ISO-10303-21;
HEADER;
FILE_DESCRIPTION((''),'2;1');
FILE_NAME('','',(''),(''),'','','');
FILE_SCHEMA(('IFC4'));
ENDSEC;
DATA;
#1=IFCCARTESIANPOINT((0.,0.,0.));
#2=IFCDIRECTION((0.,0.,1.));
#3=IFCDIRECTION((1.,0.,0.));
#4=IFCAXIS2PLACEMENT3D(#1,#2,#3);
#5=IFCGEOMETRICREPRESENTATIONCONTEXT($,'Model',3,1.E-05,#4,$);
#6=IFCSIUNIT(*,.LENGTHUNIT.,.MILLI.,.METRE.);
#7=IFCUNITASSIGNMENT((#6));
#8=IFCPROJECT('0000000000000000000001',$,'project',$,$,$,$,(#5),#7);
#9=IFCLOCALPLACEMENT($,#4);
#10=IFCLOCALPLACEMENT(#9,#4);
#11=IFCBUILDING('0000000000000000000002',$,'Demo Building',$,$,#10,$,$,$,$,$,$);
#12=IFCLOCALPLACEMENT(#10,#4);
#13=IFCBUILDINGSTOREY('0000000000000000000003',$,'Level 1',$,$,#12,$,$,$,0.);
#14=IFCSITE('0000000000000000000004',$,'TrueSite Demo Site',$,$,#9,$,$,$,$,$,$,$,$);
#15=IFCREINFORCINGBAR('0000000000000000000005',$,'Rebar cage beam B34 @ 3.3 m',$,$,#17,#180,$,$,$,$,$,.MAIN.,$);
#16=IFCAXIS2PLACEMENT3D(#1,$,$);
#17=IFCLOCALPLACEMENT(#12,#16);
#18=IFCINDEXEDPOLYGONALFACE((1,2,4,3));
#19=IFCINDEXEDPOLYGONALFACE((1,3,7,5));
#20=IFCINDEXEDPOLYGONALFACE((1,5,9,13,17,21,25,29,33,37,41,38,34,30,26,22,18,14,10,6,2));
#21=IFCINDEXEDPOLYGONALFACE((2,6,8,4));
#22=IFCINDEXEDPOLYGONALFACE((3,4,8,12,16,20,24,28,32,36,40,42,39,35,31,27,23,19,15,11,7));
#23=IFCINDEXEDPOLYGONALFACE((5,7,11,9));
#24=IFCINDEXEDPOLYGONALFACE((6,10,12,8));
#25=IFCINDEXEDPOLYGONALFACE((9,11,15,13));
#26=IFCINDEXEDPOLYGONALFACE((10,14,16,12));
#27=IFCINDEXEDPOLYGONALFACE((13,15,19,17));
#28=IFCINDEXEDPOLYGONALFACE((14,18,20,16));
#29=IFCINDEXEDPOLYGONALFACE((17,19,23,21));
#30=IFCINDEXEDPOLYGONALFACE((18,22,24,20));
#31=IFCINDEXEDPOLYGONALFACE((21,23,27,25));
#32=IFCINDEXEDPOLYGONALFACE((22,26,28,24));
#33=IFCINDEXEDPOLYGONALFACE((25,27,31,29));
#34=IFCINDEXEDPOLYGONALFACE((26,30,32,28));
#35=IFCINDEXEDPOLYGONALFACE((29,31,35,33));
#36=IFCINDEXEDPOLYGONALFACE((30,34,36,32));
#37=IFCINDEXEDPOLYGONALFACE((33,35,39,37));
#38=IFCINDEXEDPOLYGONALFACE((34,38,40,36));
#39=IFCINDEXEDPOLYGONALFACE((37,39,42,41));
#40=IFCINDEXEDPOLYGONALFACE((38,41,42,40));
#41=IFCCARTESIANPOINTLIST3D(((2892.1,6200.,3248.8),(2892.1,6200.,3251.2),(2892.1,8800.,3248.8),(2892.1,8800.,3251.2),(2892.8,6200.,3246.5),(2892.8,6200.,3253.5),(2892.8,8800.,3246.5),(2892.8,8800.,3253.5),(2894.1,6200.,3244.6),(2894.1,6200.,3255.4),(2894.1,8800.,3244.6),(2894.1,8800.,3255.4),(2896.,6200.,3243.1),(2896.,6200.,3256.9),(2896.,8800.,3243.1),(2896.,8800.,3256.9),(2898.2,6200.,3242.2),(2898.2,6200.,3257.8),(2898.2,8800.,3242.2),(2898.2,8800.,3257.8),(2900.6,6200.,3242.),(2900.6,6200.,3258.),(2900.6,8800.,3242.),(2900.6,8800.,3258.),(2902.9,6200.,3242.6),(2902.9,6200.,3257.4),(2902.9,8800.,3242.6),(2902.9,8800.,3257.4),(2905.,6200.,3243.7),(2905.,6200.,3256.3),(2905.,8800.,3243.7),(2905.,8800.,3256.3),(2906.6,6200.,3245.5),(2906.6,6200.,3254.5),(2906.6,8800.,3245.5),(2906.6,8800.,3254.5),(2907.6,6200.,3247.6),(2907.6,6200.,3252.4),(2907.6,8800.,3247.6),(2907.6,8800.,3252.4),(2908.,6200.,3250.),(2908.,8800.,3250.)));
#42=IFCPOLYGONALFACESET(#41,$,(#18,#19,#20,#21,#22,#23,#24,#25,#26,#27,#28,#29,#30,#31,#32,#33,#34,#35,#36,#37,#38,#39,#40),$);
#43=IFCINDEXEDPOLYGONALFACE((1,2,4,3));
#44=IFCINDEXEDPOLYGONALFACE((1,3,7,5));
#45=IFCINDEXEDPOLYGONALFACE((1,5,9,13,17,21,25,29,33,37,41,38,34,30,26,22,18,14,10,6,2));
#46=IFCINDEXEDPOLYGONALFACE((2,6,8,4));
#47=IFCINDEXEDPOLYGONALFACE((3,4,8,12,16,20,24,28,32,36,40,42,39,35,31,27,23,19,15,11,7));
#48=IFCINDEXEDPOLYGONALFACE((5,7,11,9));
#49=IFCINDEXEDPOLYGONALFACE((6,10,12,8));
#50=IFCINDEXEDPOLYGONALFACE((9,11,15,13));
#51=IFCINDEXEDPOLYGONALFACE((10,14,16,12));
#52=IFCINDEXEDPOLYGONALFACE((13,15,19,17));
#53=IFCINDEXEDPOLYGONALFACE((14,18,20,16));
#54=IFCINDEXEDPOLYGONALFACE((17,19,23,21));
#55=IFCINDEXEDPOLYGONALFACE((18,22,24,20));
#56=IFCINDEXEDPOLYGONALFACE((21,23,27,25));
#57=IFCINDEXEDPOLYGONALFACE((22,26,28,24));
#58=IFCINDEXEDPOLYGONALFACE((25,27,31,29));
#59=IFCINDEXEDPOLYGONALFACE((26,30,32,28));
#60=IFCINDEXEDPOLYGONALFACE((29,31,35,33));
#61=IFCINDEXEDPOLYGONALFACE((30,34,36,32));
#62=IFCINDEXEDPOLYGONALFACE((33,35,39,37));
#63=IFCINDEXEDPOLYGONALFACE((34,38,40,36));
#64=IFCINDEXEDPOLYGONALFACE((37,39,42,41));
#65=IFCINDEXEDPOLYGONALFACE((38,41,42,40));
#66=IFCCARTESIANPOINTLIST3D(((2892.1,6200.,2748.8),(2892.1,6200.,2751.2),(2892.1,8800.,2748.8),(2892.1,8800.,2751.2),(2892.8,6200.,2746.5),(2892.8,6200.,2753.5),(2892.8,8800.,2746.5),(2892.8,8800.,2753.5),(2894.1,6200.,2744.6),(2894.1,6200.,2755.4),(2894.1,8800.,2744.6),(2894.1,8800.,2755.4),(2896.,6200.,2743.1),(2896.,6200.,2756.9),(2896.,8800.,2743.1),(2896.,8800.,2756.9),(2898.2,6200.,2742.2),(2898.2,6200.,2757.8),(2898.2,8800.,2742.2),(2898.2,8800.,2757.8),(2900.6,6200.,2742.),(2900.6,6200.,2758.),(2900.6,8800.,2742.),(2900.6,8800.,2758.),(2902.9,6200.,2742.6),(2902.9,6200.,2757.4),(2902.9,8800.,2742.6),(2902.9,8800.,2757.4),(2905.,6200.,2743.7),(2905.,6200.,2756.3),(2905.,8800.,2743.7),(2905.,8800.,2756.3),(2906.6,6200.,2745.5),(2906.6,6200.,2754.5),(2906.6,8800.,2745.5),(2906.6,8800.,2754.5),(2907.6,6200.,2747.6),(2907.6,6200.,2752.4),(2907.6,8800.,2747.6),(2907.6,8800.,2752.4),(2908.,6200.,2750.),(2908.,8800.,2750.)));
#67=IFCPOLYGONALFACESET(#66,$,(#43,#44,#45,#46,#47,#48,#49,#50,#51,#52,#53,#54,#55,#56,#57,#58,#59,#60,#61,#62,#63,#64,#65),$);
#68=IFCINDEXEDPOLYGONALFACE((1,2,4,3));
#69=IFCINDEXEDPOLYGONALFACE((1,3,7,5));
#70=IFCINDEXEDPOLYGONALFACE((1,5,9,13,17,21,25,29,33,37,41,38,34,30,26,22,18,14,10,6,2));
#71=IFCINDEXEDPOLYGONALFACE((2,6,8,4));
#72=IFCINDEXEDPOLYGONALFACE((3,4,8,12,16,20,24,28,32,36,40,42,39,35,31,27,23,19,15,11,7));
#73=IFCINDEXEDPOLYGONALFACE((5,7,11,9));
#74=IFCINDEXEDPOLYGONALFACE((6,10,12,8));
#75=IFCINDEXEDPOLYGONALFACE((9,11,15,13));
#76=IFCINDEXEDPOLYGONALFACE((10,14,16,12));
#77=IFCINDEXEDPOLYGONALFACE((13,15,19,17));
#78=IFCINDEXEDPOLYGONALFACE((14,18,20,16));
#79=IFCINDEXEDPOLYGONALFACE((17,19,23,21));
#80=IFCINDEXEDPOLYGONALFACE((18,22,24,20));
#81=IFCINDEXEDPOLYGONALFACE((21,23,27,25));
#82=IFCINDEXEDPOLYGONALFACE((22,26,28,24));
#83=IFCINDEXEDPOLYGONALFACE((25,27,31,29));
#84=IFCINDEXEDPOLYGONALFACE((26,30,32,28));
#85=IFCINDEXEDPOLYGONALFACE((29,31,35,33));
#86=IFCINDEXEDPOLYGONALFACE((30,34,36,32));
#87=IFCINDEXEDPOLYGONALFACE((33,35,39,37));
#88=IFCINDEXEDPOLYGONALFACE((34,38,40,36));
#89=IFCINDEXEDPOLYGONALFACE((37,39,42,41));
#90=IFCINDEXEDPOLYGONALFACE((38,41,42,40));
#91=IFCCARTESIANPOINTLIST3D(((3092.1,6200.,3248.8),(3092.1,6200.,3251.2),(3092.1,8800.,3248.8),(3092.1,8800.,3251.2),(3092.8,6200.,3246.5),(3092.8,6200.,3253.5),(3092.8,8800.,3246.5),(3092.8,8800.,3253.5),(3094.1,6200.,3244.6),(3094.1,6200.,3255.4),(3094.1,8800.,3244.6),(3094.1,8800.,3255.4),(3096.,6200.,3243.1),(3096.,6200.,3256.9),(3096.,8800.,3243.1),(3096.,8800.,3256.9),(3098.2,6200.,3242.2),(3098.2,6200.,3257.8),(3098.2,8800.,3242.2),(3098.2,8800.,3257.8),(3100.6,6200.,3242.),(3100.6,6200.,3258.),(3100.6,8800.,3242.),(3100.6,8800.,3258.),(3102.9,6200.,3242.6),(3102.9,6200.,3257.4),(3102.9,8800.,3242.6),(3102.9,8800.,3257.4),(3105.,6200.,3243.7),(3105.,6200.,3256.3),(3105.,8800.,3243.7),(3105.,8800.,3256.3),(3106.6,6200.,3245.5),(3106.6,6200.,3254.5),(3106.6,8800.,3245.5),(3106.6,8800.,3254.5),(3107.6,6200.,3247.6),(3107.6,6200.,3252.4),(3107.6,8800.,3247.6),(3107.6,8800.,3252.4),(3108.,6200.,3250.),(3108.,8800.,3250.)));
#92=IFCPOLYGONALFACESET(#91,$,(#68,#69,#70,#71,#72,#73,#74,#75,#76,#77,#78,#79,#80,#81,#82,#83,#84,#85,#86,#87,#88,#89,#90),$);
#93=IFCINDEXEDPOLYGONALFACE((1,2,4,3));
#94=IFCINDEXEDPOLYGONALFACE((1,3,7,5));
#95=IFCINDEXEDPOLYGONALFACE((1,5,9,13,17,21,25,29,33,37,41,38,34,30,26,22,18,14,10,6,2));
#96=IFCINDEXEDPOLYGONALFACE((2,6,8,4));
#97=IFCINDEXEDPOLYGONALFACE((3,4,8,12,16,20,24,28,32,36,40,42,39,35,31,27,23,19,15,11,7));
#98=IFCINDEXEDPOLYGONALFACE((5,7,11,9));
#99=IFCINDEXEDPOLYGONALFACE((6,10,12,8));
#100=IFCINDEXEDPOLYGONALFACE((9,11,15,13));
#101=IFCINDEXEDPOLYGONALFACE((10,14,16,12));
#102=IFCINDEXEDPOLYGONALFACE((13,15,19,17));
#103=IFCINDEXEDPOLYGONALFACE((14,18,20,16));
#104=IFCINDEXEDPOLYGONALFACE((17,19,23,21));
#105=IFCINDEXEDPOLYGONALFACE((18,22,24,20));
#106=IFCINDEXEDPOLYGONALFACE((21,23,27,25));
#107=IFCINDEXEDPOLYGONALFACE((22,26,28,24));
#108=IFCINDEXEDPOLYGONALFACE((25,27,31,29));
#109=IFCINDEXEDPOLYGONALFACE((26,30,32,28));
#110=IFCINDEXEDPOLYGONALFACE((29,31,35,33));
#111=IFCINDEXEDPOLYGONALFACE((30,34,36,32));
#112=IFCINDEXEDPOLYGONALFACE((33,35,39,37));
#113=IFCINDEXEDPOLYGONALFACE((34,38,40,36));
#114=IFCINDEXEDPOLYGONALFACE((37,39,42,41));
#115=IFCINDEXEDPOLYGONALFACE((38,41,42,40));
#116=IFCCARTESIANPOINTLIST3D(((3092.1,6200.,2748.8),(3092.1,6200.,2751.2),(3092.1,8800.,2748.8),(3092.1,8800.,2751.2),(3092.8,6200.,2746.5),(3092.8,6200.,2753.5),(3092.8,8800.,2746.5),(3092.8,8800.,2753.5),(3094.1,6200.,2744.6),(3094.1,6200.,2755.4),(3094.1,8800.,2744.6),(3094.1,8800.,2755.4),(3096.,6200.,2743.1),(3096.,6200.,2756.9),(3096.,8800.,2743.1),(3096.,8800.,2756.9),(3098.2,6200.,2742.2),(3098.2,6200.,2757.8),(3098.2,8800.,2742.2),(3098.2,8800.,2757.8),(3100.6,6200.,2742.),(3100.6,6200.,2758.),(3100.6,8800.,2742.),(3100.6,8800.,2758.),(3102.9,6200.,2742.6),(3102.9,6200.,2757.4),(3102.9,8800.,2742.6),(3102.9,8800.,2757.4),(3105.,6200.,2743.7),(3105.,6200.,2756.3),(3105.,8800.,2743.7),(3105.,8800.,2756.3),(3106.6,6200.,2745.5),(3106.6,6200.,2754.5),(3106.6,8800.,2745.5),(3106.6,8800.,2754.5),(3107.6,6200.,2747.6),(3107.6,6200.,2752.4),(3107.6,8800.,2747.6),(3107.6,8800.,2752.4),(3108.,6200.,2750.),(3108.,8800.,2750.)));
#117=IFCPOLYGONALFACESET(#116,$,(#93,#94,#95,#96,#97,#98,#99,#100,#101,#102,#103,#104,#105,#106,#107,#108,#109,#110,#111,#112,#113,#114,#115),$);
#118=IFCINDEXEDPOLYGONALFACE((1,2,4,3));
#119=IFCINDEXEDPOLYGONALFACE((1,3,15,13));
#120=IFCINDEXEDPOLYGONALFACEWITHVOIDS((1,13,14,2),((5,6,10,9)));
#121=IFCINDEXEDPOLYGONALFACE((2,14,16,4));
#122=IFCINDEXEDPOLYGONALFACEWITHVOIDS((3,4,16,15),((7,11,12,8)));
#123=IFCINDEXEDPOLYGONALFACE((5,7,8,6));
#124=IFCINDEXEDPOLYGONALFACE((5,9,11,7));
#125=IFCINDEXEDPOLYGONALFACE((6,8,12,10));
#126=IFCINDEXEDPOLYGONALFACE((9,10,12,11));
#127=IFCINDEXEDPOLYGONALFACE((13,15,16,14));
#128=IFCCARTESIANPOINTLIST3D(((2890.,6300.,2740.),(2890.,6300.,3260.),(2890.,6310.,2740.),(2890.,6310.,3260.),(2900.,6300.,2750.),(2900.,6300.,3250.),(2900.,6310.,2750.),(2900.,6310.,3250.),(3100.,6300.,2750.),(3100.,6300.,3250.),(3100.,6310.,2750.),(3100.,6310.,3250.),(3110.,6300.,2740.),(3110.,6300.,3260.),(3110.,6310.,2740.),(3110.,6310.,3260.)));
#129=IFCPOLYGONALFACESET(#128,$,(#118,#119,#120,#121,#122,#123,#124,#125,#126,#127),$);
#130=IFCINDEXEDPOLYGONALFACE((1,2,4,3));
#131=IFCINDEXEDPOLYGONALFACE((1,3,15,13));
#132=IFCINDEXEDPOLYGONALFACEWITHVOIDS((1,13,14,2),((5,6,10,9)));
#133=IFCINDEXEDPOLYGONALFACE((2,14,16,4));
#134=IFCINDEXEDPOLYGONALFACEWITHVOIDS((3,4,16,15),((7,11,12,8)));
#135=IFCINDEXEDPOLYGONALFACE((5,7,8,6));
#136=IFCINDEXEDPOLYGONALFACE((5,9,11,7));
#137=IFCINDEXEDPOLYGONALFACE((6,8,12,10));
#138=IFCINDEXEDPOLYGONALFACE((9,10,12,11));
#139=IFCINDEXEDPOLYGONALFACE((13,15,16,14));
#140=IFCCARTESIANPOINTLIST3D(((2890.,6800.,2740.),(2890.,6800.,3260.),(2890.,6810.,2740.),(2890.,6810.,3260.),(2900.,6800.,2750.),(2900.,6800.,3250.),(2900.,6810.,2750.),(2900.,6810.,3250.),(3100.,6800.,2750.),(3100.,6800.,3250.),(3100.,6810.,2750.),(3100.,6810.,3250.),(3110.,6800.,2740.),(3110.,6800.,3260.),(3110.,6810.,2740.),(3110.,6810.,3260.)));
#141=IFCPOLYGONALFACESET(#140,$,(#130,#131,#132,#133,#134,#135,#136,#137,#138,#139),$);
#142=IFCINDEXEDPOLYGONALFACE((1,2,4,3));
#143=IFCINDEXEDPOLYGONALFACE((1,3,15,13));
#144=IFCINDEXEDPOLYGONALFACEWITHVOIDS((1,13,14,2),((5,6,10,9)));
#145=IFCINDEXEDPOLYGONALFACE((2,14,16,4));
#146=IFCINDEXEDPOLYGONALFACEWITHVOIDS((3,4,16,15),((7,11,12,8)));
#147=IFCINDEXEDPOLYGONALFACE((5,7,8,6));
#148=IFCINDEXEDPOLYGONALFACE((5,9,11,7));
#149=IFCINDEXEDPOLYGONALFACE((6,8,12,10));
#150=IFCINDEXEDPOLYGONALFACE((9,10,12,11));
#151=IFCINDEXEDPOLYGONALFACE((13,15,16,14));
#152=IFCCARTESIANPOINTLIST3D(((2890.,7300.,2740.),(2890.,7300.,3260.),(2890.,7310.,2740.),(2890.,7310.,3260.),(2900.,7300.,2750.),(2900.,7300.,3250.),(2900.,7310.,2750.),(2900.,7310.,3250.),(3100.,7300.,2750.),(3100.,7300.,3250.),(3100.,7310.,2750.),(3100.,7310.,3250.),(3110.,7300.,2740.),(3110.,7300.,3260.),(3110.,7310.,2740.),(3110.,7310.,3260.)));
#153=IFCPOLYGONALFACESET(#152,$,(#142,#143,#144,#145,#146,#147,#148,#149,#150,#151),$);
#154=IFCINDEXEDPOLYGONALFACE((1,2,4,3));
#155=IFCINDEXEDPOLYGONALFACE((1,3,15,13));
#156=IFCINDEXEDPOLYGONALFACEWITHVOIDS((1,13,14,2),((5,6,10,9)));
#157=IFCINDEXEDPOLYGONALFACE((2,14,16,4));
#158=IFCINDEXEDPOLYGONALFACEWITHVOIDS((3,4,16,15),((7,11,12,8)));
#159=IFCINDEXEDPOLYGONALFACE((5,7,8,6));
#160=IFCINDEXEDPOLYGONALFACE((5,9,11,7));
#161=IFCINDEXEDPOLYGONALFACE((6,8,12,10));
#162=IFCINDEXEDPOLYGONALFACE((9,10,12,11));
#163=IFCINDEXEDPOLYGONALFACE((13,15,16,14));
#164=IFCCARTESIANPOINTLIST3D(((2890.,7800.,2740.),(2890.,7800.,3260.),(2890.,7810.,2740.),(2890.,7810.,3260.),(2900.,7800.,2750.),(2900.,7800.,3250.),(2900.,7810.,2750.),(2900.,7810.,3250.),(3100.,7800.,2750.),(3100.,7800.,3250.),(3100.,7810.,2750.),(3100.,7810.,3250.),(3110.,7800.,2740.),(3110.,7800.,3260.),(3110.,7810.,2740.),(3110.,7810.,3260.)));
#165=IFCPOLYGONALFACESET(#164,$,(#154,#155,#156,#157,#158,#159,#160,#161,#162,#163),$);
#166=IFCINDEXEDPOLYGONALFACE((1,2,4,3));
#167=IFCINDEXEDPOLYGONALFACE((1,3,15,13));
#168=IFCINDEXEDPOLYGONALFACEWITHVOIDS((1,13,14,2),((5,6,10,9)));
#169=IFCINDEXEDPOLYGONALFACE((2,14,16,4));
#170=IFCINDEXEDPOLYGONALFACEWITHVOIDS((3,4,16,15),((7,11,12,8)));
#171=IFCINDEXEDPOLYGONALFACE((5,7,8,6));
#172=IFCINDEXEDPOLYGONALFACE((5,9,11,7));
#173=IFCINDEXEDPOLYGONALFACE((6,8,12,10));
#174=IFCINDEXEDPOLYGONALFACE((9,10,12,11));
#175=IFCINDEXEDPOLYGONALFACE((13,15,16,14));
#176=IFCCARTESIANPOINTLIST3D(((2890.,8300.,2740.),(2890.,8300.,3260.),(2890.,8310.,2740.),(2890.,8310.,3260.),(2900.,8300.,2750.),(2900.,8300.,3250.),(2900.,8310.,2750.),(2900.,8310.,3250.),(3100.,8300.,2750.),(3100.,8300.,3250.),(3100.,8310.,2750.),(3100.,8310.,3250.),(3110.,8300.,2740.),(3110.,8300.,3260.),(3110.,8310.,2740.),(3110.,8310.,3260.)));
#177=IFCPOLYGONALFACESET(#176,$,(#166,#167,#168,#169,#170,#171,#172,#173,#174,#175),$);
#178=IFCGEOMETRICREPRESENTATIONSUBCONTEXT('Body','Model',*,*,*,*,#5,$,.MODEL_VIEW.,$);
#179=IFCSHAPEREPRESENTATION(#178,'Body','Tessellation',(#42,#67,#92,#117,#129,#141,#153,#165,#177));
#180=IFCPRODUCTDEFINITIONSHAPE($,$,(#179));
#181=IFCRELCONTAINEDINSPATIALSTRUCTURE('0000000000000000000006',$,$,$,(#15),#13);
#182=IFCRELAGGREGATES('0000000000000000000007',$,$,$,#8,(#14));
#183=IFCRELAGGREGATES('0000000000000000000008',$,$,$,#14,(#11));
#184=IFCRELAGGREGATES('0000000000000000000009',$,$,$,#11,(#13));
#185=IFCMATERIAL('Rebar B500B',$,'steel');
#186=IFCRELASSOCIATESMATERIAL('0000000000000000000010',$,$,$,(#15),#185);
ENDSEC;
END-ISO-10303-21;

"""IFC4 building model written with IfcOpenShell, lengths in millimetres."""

from ifc_helpers import new_model, si_unit, frame, origin_with_axes, place, context, subcontext, project, spatial, hollow_rectangle, circle, extrude, material, element, save


model = new_model("IFC4")

# Units and contexts
model_context = context("Model", 3, precision=1e-05, world=origin_with_axes())
body_context = subcontext(model_context, "Body", "Model", "MODEL_VIEW")
ifc_project = project(units=[si_unit("LENGTHUNIT", "METRE", prefix="MILLI")], contexts=[model_context])

# Site, building, storey
site_placement = place(None, origin_with_axes())
site = spatial("IfcSite", under=ifc_project, at=site_placement, Name="TrueSite Demo Site")
building_placement = place(site_placement, origin_with_axes())
building = spatial("IfcBuilding", under=site, at=building_placement, Name="Demo Building")
storey_placement = place(building_placement, origin_with_axes())
storey = spatial("IfcBuildingStorey", under=building, at=storey_placement, Name="Level 1", Elevation=0.0)

# Reinforcing bar
ifc_material_1 = material(Name="Rebar B500B", Category="steel")
reinforcing_bar_1_placement = place(storey_placement, frame((3000.0, 6200.0, 3000.0), z_axis=(0.0, 1.0, 0.0), x_axis=(1.0, 0.0, 0.0)))
element("IfcReinforcingBar", 1, at=reinforcing_bar_1_placement, inside=storey, material=ifc_material_1, Name="Rebar cage beam B34 @ 3.3 m", PredefinedType="MAIN", context=body_context, shape_type="SweptSolid", body=[
    extrude(circle(Radius=8.0), frame((-100.0, -250.0, 0.0)), (0.0, 0.0, 1.0), 2600.0),
    extrude(circle(Radius=8.0), frame((-100.0, 250.0, 0.0)), (0.0, 0.0, 1.0), 2600.0),
    extrude(circle(Radius=8.0), frame((100.0, -250.0, 0.0)), (0.0, 0.0, 1.0), 2600.0),
    extrude(circle(Radius=8.0), frame((100.0, 250.0, 0.0)), (0.0, 0.0, 1.0), 2600.0),
    extrude(hollow_rectangle(XDim=220.0, YDim=520.0, WallThickness=10.0), frame((0.0, 0.0, 100.0)), (0.0, 0.0, 1.0), 10.0),
    extrude(hollow_rectangle(XDim=220.0, YDim=520.0, WallThickness=10.0), frame((0.0, 0.0, 600.0)), (0.0, 0.0, 1.0), 10.0),
    extrude(hollow_rectangle(XDim=220.0, YDim=520.0, WallThickness=10.0), frame((0.0, 0.0, 1100.0)), (0.0, 0.0, 1.0), 10.0),
    extrude(hollow_rectangle(XDim=220.0, YDim=520.0, WallThickness=10.0), frame((0.0, 0.0, 1600.0)), (0.0, 0.0, 1.0), 10.0),
    extrude(hollow_rectangle(XDim=220.0, YDim=520.0, WallThickness=10.0), frame((0.0, 0.0, 2100.0)), (0.0, 0.0, 1.0), 10.0),
])

save(model, "model.ifc")
